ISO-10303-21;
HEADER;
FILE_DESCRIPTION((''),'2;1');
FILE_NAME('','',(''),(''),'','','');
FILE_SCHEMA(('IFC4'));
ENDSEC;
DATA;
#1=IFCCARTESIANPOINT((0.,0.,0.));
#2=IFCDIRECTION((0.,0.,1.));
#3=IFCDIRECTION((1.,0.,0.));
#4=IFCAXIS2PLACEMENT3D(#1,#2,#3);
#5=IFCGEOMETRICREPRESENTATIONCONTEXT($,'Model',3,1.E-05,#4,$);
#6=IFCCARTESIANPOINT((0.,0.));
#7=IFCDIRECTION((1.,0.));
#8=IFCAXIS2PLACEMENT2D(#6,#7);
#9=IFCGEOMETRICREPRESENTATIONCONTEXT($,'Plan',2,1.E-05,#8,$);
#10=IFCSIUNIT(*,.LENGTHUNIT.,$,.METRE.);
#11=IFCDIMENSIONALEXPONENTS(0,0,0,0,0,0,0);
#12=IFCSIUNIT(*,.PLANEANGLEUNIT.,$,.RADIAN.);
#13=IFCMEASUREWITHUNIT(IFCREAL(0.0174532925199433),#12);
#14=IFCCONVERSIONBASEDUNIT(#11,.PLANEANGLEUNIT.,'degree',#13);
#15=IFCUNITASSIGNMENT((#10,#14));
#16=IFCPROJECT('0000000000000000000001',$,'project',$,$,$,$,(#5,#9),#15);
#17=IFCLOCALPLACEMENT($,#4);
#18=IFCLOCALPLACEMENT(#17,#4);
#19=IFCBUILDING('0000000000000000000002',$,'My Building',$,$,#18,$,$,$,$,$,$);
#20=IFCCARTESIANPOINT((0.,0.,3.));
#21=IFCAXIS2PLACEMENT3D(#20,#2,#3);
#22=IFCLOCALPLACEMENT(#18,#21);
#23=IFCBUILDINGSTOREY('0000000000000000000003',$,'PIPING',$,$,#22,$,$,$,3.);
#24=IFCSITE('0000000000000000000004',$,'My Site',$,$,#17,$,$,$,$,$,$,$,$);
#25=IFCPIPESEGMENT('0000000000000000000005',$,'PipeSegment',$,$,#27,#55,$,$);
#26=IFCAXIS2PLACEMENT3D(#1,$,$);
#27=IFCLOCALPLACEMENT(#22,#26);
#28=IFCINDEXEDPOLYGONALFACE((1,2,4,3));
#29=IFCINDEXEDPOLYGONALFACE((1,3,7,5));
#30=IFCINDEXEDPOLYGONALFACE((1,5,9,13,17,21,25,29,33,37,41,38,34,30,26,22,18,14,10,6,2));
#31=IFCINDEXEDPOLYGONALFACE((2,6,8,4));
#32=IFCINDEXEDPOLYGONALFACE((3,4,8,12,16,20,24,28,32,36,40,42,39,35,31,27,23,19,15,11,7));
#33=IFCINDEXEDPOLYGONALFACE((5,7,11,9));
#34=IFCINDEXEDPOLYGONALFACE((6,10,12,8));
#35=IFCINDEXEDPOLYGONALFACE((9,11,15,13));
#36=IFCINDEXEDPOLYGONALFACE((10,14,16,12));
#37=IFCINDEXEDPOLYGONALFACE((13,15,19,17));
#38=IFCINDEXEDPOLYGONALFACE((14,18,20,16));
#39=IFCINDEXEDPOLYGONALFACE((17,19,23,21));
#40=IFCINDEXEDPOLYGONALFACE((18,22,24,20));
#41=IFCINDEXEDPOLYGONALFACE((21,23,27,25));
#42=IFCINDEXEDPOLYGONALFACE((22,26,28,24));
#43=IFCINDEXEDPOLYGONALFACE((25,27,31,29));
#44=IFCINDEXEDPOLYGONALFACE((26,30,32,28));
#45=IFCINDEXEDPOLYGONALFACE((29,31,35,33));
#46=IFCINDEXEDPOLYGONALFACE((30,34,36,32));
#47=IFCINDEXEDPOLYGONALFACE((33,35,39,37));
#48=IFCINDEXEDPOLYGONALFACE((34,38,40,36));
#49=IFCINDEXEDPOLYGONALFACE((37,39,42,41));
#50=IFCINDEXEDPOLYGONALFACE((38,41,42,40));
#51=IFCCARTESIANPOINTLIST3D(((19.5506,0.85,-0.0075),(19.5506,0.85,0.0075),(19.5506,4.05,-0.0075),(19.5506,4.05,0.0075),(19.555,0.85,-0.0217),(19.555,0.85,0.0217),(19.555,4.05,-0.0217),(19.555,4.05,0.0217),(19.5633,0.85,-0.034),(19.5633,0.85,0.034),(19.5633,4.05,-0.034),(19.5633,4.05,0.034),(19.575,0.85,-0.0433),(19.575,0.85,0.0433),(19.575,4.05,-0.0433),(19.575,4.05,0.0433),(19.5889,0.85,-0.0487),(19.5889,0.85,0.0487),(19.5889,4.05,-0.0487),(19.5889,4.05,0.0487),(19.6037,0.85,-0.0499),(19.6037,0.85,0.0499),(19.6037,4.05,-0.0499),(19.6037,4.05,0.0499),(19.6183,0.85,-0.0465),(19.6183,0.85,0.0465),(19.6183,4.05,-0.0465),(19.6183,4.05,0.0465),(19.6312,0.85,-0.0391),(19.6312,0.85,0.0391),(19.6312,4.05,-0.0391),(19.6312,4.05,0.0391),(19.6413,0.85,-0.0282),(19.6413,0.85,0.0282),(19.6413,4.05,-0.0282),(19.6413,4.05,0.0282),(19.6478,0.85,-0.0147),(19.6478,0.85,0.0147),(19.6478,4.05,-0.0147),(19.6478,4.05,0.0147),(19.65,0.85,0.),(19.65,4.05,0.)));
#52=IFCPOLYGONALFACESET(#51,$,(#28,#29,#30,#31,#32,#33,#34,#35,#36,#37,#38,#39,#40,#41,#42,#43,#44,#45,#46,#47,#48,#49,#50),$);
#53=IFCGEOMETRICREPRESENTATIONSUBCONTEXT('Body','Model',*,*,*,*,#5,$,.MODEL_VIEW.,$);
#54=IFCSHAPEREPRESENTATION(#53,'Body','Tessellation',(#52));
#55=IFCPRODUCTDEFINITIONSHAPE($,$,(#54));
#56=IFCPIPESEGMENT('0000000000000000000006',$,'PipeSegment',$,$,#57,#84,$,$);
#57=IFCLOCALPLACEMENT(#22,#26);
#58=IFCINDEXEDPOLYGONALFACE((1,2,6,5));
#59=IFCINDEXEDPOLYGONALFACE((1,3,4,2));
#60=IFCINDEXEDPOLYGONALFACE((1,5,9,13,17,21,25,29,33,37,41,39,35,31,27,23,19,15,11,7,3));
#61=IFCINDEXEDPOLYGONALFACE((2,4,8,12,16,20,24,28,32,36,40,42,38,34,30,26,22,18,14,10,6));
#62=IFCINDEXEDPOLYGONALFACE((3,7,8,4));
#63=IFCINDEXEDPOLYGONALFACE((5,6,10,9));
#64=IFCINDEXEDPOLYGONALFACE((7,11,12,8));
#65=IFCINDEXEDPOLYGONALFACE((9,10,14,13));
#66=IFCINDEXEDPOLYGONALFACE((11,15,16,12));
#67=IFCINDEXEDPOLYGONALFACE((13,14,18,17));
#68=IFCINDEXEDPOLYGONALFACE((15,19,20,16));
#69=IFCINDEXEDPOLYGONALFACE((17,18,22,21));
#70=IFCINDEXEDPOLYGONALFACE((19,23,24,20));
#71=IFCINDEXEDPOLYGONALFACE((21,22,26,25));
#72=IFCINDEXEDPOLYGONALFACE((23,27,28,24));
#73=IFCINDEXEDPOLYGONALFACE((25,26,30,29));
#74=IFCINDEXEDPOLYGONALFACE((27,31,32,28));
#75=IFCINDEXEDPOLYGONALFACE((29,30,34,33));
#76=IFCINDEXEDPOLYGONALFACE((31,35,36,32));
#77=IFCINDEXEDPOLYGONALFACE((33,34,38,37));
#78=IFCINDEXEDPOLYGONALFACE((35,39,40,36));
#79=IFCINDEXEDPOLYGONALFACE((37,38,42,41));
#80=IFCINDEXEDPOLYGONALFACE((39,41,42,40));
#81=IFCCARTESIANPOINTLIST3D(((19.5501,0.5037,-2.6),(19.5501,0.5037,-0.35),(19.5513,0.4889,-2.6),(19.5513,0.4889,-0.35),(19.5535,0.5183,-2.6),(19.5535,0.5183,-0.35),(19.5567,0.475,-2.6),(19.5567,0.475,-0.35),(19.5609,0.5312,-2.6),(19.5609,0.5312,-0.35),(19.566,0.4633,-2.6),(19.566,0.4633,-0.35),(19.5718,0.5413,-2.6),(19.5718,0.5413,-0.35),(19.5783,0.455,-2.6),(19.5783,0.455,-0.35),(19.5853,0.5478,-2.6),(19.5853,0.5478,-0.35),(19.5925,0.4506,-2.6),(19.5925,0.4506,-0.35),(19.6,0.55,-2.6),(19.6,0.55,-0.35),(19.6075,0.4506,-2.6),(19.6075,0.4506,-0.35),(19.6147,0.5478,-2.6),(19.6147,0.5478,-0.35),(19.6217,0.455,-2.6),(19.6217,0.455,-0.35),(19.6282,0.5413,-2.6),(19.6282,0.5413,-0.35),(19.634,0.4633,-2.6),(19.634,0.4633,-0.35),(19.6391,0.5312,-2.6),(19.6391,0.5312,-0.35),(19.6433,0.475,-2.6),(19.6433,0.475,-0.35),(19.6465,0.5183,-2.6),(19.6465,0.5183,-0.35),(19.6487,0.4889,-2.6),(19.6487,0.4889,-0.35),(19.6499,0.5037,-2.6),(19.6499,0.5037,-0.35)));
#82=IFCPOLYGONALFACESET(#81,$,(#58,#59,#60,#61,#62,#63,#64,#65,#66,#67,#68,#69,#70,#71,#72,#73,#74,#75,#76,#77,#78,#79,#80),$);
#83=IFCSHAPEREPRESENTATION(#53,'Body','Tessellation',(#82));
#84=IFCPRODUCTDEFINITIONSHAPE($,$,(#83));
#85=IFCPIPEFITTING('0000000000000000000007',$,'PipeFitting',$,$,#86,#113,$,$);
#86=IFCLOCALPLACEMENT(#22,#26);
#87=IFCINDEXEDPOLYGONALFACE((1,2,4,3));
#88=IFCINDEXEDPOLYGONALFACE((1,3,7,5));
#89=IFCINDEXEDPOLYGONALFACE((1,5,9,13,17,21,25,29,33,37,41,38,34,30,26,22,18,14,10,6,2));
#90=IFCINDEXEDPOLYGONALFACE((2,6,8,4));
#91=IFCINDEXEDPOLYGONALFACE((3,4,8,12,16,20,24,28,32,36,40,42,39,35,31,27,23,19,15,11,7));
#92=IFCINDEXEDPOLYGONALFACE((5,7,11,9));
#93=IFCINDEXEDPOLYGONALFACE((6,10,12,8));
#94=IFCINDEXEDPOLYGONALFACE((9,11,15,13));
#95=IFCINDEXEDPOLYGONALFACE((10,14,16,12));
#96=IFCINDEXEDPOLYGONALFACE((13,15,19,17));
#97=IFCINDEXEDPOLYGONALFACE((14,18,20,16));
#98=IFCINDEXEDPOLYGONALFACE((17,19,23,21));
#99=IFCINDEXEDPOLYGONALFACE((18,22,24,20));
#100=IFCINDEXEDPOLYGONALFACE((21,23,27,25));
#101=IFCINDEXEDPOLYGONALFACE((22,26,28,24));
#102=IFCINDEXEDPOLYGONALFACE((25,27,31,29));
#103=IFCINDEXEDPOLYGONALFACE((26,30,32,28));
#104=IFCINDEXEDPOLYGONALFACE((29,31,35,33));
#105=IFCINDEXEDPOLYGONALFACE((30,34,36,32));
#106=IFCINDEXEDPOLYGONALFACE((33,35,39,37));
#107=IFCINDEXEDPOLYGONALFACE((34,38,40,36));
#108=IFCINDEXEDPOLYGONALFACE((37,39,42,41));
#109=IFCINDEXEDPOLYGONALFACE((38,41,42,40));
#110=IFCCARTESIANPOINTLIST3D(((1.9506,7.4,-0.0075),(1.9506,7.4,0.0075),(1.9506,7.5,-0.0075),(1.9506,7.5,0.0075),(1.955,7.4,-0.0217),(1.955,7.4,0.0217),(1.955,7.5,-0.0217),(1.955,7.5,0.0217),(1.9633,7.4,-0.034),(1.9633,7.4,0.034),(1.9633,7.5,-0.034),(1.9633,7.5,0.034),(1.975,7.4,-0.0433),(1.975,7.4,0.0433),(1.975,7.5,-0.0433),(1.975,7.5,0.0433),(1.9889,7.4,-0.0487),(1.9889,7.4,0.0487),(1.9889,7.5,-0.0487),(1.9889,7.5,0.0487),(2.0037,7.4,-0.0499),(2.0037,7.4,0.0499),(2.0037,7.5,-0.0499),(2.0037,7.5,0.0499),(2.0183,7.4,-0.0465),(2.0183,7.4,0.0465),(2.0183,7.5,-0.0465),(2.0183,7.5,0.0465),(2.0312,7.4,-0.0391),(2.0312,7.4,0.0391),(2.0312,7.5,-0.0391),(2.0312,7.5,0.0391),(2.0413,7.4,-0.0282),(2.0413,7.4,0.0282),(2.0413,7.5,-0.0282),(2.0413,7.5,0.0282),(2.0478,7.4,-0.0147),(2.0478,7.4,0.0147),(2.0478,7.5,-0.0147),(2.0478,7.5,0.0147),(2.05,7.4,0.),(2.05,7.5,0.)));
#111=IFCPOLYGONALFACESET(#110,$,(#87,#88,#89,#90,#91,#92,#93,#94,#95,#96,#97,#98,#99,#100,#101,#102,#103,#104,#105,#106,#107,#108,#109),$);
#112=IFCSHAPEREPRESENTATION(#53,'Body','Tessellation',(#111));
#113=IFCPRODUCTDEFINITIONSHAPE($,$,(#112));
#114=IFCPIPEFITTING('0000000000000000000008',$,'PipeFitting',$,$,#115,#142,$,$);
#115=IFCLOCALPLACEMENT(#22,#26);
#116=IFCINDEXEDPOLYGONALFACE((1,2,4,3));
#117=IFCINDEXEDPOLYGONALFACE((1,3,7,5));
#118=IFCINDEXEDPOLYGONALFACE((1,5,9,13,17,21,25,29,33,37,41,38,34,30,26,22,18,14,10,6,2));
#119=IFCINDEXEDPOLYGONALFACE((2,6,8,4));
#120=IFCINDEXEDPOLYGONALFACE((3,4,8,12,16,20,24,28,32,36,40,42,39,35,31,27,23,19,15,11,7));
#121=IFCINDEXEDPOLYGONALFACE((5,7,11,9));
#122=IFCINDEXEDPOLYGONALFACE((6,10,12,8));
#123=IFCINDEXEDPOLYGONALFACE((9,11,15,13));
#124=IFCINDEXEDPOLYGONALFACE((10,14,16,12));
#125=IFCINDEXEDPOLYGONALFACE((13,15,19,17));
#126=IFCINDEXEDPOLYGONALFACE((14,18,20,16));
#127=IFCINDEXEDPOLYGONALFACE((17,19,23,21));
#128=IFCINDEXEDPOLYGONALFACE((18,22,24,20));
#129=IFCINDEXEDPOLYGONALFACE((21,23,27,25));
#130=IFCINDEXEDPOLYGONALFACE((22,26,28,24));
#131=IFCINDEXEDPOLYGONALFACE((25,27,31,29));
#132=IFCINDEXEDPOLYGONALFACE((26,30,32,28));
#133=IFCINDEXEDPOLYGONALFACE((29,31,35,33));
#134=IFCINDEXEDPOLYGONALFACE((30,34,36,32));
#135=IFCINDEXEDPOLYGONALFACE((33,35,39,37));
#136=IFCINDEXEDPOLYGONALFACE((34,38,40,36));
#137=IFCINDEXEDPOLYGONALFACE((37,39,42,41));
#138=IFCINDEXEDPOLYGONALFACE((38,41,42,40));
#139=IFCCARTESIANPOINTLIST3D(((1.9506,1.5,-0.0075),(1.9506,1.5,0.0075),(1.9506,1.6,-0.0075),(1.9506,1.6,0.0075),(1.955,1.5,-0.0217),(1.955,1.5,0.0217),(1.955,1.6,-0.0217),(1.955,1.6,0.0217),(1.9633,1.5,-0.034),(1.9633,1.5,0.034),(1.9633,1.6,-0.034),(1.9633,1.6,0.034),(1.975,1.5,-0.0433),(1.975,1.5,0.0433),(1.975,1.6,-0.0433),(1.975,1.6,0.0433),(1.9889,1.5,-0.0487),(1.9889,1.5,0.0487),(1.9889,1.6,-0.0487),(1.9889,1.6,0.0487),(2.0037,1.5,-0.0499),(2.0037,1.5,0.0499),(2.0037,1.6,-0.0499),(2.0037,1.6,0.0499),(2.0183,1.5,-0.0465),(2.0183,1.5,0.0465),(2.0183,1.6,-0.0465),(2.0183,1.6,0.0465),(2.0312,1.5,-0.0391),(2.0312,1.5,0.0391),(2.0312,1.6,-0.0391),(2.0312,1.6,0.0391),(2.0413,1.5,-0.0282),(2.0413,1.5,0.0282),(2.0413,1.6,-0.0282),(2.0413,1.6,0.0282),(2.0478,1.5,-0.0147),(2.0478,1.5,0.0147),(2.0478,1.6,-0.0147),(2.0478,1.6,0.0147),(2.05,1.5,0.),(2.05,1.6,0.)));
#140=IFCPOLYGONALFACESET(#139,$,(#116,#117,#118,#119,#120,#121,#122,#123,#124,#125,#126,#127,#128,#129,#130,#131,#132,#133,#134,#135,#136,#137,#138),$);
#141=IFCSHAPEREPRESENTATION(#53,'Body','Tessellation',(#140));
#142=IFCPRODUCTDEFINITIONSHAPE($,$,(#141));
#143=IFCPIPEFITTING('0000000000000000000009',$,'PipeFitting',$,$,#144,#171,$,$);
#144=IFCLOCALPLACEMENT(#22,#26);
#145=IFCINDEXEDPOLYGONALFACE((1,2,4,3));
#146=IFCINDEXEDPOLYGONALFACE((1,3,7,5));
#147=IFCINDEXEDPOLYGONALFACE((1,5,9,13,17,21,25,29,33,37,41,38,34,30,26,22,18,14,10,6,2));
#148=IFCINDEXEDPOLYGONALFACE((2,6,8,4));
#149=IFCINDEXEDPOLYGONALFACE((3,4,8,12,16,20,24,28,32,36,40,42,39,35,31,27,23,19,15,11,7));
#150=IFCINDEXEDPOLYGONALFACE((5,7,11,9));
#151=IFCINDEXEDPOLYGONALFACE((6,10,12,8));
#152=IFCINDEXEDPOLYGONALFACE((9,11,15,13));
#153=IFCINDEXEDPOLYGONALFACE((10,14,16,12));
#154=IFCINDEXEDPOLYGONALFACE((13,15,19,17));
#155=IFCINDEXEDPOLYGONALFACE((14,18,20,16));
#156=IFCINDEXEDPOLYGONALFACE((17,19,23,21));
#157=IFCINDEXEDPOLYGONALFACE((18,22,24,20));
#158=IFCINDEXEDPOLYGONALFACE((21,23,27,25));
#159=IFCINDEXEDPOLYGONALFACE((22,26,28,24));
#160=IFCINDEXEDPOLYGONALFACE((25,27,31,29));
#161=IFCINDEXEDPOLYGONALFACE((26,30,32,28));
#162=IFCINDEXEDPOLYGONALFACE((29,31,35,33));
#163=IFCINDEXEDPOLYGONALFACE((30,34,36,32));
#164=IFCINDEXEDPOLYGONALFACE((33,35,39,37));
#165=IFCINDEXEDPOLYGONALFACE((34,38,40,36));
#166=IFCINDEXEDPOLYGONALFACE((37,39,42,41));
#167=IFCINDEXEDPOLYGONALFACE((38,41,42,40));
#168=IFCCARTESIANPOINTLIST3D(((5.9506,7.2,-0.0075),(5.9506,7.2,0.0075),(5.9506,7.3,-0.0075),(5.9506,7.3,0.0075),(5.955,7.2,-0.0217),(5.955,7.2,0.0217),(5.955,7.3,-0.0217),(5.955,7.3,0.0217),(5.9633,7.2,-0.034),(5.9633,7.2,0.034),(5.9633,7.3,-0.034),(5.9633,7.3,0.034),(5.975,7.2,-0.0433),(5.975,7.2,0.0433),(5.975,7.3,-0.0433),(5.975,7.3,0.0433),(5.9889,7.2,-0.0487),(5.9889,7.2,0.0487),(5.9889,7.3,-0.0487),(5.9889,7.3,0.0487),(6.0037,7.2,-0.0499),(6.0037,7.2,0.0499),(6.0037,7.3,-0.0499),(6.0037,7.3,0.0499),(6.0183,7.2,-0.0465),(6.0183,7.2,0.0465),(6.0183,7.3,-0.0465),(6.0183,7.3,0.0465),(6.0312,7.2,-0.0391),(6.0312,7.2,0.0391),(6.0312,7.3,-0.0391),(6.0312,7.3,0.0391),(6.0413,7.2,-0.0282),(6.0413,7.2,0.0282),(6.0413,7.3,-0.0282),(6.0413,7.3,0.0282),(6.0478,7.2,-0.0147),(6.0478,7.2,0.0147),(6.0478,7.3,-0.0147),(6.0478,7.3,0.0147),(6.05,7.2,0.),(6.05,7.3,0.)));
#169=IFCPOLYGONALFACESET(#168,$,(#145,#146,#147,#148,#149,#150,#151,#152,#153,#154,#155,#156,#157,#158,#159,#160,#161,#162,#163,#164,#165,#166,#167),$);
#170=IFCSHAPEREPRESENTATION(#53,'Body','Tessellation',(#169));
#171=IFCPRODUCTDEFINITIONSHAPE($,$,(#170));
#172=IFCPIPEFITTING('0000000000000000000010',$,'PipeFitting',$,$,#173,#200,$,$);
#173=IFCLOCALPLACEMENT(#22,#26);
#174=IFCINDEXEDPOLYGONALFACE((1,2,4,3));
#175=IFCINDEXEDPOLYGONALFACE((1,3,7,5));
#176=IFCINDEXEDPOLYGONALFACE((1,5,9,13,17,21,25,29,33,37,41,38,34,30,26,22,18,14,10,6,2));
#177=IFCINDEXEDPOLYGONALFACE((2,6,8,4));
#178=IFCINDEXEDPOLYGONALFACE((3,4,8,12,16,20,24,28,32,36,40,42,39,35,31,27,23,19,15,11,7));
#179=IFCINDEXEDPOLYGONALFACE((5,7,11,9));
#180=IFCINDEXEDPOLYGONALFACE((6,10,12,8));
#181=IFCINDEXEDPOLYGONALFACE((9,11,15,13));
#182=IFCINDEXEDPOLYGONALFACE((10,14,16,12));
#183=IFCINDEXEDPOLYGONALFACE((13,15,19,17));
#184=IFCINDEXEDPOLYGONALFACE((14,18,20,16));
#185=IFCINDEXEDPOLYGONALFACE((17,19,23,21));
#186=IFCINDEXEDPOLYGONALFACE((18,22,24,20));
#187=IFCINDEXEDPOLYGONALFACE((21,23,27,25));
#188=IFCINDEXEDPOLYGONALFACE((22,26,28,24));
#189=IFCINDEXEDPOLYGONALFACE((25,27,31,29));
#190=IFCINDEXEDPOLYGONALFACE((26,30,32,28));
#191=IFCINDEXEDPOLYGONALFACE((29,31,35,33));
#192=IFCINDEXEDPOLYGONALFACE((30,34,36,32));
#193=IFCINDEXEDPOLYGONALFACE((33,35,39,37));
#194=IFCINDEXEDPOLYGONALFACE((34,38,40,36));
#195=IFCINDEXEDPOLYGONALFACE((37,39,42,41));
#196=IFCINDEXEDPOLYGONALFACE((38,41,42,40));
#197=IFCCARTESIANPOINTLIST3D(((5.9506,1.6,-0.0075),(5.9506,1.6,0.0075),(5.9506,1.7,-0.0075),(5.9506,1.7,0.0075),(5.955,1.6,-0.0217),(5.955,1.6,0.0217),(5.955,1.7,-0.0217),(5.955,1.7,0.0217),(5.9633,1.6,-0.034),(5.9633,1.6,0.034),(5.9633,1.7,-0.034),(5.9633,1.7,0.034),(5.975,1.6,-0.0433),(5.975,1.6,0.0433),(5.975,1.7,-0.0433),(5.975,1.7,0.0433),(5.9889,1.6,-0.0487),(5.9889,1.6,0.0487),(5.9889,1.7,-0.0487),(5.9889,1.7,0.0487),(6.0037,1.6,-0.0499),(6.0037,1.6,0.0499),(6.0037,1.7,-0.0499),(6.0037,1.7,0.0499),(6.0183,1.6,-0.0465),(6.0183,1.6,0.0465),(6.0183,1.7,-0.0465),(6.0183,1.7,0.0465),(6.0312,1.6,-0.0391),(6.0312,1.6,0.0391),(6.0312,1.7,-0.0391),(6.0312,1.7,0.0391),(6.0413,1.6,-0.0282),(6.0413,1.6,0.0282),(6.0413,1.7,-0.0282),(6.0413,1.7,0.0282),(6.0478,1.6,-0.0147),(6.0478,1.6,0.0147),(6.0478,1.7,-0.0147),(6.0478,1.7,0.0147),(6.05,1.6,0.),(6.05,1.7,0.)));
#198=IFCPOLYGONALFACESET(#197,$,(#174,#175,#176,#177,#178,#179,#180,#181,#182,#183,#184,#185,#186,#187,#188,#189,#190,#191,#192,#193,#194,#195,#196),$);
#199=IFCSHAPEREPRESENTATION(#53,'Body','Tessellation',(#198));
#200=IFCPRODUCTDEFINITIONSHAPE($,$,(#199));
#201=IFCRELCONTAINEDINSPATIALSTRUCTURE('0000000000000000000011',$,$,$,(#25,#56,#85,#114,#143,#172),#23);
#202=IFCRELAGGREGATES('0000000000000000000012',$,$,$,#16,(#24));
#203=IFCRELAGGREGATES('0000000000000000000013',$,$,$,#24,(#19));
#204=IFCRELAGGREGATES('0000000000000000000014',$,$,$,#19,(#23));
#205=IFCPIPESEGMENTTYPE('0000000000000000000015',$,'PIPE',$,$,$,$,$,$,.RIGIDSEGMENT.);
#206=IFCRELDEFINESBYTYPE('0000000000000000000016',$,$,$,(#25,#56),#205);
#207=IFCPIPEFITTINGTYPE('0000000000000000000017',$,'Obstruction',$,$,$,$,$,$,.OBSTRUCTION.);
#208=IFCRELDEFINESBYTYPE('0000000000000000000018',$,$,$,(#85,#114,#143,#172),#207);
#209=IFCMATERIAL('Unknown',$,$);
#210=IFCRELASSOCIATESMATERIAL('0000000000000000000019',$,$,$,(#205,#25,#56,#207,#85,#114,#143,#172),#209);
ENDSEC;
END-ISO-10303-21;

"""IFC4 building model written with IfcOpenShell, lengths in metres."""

from ifc_helpers import new_model, entity, si_unit, converted_unit, frame, origin_with_axes, origin_2d_with_axis, place, context, subcontext, project, spatial, circle, extrude, material, material_profile, profile_set, profile_usage, type_object, element, save


model = new_model("IFC4")

# Units and contexts
model_context = context("Model", 3, precision=1e-05, world=origin_with_axes())
plan_context = context("Plan", 2, precision=1e-05, world=origin_2d_with_axis())
body_context = subcontext(model_context, "Body", "Model", "MODEL_VIEW")
ifc_project = project(units=[si_unit("LENGTHUNIT", "METRE"), converted_unit("PLANEANGLEUNIT", "degree", entity("IfcReal", 0.0174532925199433), si_unit("PLANEANGLEUNIT", "RADIAN"), dimensions=[0, 0, 0, 0, 0, 0, 0])], contexts=[model_context, plan_context])

# Site, building, storey
site_placement = place(None, origin_with_axes())
site = spatial("IfcSite", under=ifc_project, at=site_placement, Name="My Site")
building_placement = place(site_placement, origin_with_axes())
building = spatial("IfcBuilding", under=site, at=building_placement, Name="My Building")
storey_placement = place(building_placement, frame((0.0, 0.0, 3.0), z_axis=(0.0, 0.0, 1.0), x_axis=(1.0, 0.0, 0.0)))
storey = spatial("IfcBuildingStorey", under=building, at=storey_placement, Name="PIPING", Elevation=3.0)

# Pipe segments
ifc_material = material(Name="Unknown")
ifc_material_profile_1 = material_profile(ifc_material, circle(Radius=0.05))
ifc_profile_set_1 = profile_set([ifc_material_profile_1])
pipe_segment_type = type_object("IfcPipeSegmentType", Name="PIPE", PredefinedType="RIGIDSEGMENT", material=ifc_profile_set_1)
ifc_profile_usage_1 = profile_usage(ifc_profile_set_1, cardinal=5)
pipe_segment_1_placement = place(storey_placement, frame((19.6, 4.05, 0.0), z_axis=(0.0, -1.0, 0.0), x_axis=(1.0, 0.0, 0.0)))
element("IfcPipeSegment", 1, at=pipe_segment_1_placement, inside=storey, type_object=pipe_segment_type, material=ifc_profile_usage_1, Name="PipeSegment", context=body_context, shape_type="SweptSolid", body=[
    extrude(circle(Radius=0.05), origin_with_axes(), (0.0, 0.0, 1.0), 3.2),
])
ifc_profile_usage_2 = profile_usage(ifc_profile_set_1, cardinal=5)
pipe_segment_2_placement = place(storey_placement, frame((19.6, 0.5, -0.35), z_axis=(0.0, 0.0, -1.0), x_axis=(0.0, 1.0, 0.0)))
element("IfcPipeSegment", 2, at=pipe_segment_2_placement, inside=storey, type_object=pipe_segment_type, material=ifc_profile_usage_2, Name="PipeSegment", context=body_context, shape_type="SweptSolid", body=[
    extrude(circle(Radius=0.05), origin_with_axes(), (0.0, 0.0, 1.0), 2.25),
])

# Pipe fittings
ifc_material_profile_2 = material_profile(ifc_material, circle(Radius=0.05))
ifc_profile_set_2 = profile_set([ifc_material_profile_2])
ifc_profile_usage_3 = profile_usage(ifc_profile_set_2, cardinal=5)
pipe_fitting_type = type_object("IfcPipeFittingType", Name="Obstruction", PredefinedType="OBSTRUCTION", material=ifc_profile_set_2)
pipe_fitting_1_placement = place(storey_placement, frame((2.0, 7.5, 0.0), z_axis=(0.0, -1.0, 0.0), x_axis=(1.0, 0.0, 0.0)))
element("IfcPipeFitting", 3, at=pipe_fitting_1_placement, inside=storey, type_object=pipe_fitting_type, material=ifc_profile_usage_3, Name="PipeFitting", context=body_context, shape_type="SweptSolid", body=[
    extrude(circle(Radius=0.05), origin_with_axes(), (0.0, 0.0, 1.0), 0.1),
])
ifc_profile_usage_4 = profile_usage(ifc_profile_set_2, cardinal=5)
pipe_fitting_2_placement = place(storey_placement, frame((2.0, 1.6, 0.0), z_axis=(0.0, -1.0, 0.0), x_axis=(1.0, 0.0, 0.0)))
element("IfcPipeFitting", 4, at=pipe_fitting_2_placement, inside=storey, type_object=pipe_fitting_type, material=ifc_profile_usage_4, Name="PipeFitting", context=body_context, shape_type="SweptSolid", body=[
    extrude(circle(Radius=0.05), origin_with_axes(), (0.0, 0.0, 1.0), 0.1),
])
ifc_profile_usage_5 = profile_usage(ifc_profile_set_2, cardinal=5)
pipe_fitting_3_placement = place(storey_placement, frame((6.0, 7.3, 0.0), z_axis=(0.0, -1.0, 0.0), x_axis=(1.0, 0.0, 0.0)))
element("IfcPipeFitting", 5, at=pipe_fitting_3_placement, inside=storey, type_object=pipe_fitting_type, material=ifc_profile_usage_5, Name="PipeFitting", context=body_context, shape_type="SweptSolid", body=[
    extrude(circle(Radius=0.05), origin_with_axes(), (0.0, 0.0, 1.0), 0.1),
])
ifc_profile_usage_6 = profile_usage(ifc_profile_set_2, cardinal=5)
pipe_fitting_4_placement = place(storey_placement, frame((6.0, 1.7, 0.0), z_axis=(0.0, -1.0, 0.0), x_axis=(1.0, 0.0, 0.0)))
element("IfcPipeFitting", 6, at=pipe_fitting_4_placement, inside=storey, type_object=pipe_fitting_type, material=ifc_profile_usage_6, Name="PipeFitting", context=body_context, shape_type="SweptSolid", body=[
    extrude(circle(Radius=0.05), origin_with_axes(), (0.0, 0.0, 1.0), 0.1),
])

save(model, "model.ifc")
